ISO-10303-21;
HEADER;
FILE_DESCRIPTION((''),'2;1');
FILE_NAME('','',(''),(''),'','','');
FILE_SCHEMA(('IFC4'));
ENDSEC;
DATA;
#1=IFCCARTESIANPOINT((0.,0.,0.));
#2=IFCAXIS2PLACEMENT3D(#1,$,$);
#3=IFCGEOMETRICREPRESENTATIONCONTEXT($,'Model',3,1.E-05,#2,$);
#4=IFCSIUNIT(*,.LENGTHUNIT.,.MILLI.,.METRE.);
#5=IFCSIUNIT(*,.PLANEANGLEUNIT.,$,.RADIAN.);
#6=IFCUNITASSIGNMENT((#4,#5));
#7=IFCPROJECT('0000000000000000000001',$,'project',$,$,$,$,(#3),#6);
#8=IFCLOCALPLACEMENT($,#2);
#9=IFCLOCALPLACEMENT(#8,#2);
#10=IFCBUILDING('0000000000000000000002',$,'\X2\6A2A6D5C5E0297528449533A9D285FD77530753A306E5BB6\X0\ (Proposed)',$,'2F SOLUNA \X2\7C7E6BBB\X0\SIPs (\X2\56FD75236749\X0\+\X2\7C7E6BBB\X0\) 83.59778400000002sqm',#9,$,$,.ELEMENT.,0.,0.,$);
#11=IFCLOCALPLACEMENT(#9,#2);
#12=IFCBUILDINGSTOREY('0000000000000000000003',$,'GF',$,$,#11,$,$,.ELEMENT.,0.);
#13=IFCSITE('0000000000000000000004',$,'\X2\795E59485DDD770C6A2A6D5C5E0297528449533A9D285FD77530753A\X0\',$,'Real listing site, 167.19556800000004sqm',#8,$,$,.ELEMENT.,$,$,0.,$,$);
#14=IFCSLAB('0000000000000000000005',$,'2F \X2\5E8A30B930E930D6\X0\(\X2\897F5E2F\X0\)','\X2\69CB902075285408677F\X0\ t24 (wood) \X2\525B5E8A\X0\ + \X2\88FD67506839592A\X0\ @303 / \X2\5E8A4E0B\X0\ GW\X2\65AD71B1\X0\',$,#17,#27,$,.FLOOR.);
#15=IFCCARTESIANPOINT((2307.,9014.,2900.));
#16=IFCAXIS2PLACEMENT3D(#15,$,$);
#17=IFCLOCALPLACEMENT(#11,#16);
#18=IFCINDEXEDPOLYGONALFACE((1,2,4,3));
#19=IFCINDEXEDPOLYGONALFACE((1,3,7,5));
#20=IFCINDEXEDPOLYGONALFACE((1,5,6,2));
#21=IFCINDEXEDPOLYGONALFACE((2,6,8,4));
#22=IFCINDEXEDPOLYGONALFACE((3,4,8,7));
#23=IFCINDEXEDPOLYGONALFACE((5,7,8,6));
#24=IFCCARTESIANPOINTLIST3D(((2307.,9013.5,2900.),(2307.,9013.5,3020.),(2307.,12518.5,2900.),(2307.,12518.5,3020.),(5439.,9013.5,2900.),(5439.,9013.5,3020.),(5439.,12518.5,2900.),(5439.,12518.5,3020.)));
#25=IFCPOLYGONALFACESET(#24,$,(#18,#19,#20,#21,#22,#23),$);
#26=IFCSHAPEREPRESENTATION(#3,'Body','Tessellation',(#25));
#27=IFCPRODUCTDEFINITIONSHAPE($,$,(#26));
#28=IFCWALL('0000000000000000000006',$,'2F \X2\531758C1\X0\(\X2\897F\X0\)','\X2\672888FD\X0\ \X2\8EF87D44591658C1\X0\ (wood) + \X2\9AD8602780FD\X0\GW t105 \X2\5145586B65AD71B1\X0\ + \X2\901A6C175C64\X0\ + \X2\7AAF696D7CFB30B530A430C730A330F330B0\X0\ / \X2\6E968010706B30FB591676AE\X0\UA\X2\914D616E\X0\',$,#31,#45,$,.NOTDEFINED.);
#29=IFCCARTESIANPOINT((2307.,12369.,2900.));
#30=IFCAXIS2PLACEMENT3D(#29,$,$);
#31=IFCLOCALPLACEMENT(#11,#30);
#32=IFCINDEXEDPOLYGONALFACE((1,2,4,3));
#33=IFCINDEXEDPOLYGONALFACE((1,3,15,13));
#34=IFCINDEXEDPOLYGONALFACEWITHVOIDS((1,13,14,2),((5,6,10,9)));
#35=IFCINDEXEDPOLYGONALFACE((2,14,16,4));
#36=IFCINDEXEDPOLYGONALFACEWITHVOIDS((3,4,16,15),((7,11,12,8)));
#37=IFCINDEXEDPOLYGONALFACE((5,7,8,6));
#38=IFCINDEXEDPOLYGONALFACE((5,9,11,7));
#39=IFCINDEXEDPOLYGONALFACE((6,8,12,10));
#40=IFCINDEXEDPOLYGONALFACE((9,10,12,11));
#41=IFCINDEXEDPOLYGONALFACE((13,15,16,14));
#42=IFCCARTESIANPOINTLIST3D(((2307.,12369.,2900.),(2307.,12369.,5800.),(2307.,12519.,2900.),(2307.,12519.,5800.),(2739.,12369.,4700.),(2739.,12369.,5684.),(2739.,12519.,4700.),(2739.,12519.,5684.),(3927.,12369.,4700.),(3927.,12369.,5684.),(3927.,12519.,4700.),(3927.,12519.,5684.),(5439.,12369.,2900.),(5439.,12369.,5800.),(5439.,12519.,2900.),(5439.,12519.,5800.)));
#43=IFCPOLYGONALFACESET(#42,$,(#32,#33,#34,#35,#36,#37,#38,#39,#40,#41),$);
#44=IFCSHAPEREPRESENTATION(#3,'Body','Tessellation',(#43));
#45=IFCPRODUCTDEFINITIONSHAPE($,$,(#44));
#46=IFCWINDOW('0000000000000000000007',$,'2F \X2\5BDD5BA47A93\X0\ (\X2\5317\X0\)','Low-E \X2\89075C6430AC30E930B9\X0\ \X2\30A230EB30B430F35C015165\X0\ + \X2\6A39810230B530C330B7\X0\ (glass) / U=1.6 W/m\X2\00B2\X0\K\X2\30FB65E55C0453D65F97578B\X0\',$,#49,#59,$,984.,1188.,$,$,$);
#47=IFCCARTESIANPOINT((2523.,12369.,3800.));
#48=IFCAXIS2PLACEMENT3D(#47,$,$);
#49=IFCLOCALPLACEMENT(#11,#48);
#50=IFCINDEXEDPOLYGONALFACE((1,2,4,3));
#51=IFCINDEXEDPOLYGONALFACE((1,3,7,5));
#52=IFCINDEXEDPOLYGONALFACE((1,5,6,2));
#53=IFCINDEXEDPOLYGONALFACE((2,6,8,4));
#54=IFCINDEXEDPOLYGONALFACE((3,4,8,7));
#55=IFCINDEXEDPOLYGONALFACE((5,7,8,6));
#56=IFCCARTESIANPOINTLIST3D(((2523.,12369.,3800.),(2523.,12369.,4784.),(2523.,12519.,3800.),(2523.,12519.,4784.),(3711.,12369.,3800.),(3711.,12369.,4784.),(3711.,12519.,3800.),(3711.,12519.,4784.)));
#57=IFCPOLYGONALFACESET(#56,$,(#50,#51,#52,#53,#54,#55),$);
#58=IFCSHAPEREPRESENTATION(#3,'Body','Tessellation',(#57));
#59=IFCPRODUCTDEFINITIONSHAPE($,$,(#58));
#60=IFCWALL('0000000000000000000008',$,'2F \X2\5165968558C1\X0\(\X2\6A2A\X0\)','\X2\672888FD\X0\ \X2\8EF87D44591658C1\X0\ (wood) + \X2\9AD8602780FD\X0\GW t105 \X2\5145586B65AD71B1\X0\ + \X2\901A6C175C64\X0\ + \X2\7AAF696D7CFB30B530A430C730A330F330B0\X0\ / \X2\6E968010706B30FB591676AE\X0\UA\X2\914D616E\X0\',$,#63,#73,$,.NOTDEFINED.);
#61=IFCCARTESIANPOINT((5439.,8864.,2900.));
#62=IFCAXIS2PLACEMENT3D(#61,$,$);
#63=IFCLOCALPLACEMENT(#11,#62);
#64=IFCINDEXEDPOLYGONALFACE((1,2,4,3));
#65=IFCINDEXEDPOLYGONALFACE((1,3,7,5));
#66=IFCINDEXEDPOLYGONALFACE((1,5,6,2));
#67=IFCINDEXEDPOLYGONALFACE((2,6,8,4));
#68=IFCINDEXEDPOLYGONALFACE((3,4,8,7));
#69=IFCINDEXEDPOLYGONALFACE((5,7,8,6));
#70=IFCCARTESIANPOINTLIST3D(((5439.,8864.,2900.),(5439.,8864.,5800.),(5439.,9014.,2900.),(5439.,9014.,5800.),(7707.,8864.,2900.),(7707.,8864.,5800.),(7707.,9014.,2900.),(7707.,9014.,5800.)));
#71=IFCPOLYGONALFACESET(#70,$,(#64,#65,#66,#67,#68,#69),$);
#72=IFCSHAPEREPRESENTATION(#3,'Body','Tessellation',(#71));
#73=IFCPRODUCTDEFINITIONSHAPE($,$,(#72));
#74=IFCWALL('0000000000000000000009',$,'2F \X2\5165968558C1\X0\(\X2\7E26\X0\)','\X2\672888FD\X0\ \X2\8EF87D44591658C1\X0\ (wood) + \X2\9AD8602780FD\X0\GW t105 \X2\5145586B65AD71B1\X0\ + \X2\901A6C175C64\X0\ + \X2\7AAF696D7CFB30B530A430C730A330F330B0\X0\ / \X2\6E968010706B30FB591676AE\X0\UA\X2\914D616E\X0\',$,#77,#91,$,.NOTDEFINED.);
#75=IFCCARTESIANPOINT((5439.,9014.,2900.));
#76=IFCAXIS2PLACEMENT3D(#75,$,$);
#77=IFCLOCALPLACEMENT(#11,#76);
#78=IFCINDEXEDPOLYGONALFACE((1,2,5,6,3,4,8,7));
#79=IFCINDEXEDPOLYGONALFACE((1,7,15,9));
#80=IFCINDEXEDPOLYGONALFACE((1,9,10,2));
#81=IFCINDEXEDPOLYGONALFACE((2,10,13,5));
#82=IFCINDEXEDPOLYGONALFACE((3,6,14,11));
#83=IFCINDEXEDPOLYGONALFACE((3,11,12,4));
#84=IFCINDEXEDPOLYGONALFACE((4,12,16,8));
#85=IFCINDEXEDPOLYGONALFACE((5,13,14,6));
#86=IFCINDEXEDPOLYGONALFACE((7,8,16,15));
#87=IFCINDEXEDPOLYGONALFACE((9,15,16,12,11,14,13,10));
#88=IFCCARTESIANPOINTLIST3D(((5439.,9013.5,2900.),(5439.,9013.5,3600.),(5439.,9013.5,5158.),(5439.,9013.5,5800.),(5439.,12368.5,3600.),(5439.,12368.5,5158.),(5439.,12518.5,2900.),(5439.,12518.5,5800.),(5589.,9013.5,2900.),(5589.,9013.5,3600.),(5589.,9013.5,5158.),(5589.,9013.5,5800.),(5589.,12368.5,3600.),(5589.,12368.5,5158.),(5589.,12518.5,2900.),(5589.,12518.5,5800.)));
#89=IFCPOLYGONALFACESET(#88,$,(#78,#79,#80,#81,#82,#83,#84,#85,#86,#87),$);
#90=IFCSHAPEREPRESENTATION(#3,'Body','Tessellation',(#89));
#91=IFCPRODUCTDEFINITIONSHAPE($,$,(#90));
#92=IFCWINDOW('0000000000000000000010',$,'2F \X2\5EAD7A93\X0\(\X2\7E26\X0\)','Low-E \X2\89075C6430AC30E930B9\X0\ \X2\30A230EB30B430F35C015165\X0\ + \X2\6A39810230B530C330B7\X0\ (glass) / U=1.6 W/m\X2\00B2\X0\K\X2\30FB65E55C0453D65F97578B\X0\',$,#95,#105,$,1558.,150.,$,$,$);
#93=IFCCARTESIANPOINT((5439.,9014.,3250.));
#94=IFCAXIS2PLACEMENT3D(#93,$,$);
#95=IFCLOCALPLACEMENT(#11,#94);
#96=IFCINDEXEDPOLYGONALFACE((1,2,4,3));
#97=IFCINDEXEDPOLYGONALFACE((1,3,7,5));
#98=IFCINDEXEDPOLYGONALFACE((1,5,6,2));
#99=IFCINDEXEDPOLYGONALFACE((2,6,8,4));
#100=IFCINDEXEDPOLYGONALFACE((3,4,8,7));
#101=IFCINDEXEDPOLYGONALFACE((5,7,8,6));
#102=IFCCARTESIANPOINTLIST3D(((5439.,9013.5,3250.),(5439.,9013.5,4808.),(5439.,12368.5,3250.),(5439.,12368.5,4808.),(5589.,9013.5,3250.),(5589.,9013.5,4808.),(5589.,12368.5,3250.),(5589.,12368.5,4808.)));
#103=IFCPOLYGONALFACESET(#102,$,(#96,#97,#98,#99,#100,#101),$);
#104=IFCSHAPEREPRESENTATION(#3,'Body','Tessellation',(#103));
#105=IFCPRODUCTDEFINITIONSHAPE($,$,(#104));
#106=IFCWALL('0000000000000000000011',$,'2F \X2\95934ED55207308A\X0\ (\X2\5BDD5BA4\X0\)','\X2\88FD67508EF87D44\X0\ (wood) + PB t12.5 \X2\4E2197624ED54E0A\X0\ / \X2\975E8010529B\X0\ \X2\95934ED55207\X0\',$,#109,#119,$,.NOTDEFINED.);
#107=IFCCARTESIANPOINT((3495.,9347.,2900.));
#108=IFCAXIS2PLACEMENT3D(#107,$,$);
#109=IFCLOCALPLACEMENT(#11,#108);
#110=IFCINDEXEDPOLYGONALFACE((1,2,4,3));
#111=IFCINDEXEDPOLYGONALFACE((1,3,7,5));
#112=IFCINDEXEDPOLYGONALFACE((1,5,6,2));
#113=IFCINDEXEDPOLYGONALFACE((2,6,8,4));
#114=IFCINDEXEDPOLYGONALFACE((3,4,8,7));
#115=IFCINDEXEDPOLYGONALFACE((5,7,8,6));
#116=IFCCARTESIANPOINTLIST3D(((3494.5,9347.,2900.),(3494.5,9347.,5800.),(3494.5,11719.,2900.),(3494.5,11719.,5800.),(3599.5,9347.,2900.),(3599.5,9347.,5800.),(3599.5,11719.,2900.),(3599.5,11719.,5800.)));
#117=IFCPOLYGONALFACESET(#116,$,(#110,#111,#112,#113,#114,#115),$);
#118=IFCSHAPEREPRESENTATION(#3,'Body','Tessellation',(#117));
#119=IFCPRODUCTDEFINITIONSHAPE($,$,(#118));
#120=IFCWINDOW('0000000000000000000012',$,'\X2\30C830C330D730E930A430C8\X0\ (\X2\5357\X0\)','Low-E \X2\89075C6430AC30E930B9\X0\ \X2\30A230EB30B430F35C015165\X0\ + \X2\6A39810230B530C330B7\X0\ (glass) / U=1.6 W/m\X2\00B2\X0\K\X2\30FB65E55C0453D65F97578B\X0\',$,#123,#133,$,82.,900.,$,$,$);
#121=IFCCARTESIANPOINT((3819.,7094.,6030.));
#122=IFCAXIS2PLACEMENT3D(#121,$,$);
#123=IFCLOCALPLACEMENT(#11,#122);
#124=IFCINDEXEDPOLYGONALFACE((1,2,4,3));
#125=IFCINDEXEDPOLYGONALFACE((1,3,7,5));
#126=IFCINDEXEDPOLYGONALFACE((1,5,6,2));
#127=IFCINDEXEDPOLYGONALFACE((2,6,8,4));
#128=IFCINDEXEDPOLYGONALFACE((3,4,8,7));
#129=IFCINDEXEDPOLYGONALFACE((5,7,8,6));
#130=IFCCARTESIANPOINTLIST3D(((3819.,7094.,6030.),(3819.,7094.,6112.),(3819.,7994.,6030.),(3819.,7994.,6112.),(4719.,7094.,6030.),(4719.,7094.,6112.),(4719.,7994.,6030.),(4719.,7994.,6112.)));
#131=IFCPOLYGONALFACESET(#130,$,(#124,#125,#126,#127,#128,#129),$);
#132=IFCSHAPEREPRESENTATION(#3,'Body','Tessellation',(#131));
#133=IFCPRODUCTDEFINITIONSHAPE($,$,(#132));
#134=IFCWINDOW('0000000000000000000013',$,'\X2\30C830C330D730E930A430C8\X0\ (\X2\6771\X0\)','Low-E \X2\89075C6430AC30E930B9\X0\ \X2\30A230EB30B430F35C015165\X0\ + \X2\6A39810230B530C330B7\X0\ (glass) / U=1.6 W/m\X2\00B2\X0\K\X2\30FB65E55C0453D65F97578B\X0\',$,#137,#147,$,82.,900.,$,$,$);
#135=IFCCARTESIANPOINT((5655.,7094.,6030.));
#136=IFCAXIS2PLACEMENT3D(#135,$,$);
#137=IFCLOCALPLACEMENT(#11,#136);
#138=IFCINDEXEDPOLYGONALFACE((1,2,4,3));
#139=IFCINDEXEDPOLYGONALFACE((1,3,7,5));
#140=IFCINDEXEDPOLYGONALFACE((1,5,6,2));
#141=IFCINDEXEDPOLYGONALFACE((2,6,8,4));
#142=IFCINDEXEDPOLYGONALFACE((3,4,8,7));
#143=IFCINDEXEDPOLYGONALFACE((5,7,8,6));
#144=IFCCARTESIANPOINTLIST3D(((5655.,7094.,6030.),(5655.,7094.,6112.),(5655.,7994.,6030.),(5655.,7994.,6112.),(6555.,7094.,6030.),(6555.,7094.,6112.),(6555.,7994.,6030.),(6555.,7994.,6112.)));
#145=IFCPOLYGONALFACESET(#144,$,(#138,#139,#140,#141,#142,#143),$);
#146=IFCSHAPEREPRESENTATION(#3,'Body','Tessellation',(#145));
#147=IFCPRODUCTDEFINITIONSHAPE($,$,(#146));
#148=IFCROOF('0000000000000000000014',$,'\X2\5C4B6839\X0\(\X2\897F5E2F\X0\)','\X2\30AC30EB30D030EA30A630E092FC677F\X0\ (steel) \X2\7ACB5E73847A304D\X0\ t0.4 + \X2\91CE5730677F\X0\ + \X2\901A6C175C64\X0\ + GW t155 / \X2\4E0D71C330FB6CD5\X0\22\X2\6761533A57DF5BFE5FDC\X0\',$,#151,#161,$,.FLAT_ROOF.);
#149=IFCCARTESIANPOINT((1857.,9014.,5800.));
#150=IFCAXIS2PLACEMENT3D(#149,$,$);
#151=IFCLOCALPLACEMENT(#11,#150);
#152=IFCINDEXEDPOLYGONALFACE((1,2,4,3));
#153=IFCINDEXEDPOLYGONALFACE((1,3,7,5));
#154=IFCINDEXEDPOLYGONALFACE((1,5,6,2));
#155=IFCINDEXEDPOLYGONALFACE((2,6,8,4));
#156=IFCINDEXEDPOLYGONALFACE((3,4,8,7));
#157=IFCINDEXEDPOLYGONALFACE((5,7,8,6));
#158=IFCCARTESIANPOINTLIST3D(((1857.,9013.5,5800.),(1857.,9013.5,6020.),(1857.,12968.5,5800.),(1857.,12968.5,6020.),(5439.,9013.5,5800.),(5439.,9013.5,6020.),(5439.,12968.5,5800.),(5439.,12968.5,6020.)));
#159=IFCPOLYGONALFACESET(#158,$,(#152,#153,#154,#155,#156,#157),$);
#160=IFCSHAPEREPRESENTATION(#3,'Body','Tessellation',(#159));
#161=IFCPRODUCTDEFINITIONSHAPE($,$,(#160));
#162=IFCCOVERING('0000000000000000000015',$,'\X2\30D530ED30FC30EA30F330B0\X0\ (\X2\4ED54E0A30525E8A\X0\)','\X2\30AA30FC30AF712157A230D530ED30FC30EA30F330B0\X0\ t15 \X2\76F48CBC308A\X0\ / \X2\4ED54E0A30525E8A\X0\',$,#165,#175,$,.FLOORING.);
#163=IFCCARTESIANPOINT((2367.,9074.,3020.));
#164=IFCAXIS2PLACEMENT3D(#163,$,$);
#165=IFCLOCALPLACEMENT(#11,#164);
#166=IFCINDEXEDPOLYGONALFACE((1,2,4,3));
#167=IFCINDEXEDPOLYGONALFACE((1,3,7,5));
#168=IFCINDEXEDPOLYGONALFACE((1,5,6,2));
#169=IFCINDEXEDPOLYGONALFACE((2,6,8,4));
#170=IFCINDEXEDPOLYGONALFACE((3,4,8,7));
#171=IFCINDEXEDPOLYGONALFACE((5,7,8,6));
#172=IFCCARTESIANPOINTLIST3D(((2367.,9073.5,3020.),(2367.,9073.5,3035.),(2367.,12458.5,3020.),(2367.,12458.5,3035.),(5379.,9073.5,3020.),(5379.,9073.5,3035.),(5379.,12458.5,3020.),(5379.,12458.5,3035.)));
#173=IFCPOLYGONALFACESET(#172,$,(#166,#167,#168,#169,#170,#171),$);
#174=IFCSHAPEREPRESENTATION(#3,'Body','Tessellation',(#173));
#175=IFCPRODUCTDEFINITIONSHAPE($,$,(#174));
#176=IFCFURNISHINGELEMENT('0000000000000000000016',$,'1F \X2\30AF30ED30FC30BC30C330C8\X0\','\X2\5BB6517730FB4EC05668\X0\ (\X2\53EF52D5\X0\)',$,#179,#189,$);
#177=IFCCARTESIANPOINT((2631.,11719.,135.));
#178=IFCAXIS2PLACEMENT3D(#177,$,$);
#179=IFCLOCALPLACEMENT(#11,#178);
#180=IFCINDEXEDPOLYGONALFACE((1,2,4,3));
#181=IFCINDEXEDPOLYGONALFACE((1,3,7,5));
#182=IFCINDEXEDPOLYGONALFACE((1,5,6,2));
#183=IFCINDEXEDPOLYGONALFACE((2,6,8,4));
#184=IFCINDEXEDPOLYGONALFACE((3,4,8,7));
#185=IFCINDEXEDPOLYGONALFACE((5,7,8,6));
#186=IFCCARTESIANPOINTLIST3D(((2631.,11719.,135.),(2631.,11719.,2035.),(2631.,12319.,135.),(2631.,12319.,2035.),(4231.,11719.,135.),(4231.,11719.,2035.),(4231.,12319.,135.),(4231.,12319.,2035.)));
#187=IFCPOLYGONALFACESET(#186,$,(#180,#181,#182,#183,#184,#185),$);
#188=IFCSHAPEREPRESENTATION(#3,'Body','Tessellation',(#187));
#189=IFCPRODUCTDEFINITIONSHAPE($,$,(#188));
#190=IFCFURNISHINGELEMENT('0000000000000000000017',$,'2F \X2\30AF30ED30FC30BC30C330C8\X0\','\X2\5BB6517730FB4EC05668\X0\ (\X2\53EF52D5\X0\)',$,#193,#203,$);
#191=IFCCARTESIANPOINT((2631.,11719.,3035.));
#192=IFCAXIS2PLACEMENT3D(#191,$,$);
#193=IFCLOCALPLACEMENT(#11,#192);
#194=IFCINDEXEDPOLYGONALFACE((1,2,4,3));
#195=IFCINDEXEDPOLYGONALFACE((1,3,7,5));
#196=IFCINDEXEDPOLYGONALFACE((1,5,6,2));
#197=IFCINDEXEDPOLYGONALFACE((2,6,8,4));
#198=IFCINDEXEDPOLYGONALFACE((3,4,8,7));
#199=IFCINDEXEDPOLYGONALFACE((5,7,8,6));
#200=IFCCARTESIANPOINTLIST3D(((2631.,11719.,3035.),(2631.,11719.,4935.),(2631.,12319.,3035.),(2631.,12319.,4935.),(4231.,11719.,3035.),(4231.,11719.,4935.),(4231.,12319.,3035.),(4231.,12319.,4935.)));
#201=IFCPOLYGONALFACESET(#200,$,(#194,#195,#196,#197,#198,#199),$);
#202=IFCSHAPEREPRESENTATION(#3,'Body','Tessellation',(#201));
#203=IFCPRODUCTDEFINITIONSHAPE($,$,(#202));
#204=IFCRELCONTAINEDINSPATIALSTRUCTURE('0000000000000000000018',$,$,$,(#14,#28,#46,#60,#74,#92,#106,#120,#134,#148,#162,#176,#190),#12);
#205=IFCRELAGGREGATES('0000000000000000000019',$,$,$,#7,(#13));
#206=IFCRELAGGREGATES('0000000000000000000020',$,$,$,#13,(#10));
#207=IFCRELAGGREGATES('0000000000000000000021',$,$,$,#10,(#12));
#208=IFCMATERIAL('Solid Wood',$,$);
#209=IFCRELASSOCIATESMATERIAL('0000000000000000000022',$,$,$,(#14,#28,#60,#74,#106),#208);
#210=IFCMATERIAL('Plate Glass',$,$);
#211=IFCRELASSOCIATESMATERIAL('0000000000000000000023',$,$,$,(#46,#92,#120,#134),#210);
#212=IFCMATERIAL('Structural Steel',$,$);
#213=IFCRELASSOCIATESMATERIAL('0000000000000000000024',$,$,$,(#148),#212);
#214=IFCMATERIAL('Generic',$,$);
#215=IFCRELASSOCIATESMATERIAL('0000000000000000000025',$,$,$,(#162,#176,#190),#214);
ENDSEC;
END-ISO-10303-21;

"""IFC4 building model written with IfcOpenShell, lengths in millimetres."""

from ifc_helpers import new_model, si_unit, frame, frame_2d, origin, place, context, project, spatial, rectangle, extrude, material, element, fill, save


model = new_model("IFC4")

# Units and contexts
model_context = context("Model", 3, precision=1e-05, world=origin())
ifc_project = project(units=[si_unit("LENGTHUNIT", "METRE", prefix="MILLI"), si_unit("PLANEANGLEUNIT", "RADIAN")], contexts=[model_context])

# Site, building, storey
site_placement = place(None, origin())
site = spatial("IfcSite", under=ifc_project, at=site_placement, Name="神奈川県横浜市青葉区鴨志田町", ObjectType="Real listing site, 167.19556800000004sqm", CompositionType="ELEMENT", RefElevation=0.0)
building_placement = place(site_placement, origin())
building = spatial("IfcBuilding", under=site, at=building_placement, Name="横浜市青葉区鴨志田町の家 (Proposed)", ObjectType="2F SOLUNA 籾殻SIPs (国産杉+籾殻) 83.59778400000002sqm", CompositionType="ELEMENT", ElevationOfRefHeight=0.0, ElevationOfTerrain=0.0)
storey_placement = place(building_placement, origin())
storey = spatial("IfcBuildingStorey", under=building, at=storey_placement, Name="GF", CompositionType="ELEMENT", Elevation=0.0)

# Slab
ifc_material_1 = material(Name="Solid Wood")
slab_placement = place(storey_placement, frame((2307.0, 9014.0, 2900.0)))
element("IfcSlab", 1, at=slab_placement, inside=storey, material=ifc_material_1, Name="2F 床スラブ(西帯)", Description="構造用合板 t24 (wood) 剛床 + 製材根太 @303 / 床下 GW断熱", PredefinedType="FLOOR", context=model_context, shape_type="SweptSolid", body=[
    extrude(rectangle(XDim=3132.0, YDim=3505.0, at=frame_2d((1566.0, 1752.0))), frame((2307.0, 9014.0, 2900.0)), (0.0, 0.0, 1.0), 120.0),
])

# Wall, opening, window
wall_1_placement = place(storey_placement, frame((2307.0, 12369.0, 2900.0)))
wall_1 = element("IfcWall", 2, at=wall_1_placement, inside=storey, material=ifc_material_1, Name="2F 北壁(西)", Description="木製 軸組外壁 (wood) + 高性能GW t105 充填断熱 + 通気層 + 窯業系サイディング / 準耐火・外皮UA配慮", PredefinedType="NOTDEFINED", context=model_context, shape_type="SweptSolid", body=[
    extrude(rectangle(XDim=3132.0, YDim=150.0, at=frame_2d((1566.0, 75.0))), frame((2307.0, 12369.0, 2900.0)), (0.0, 0.0, 1.0), 2900.0),
])
opening_1_placement = place(storey_placement, frame((2523.0, 12369.0, 3800.0)))
opening_1 = element("IfcOpeningElement", 3, at=opening_1_placement, cuts=wall_1, PredefinedType="NOTDEFINED", context=model_context, shape_type="SweptSolid", body=[
    extrude(rectangle(XDim=1188.0, YDim=150.0, at=frame_2d((594.0, 75.0))), frame((2523.0, 12369.0, 3800.0)), (0.0, 0.0, 1.0), 984.0),
])
ifc_material_2 = material(Name="Plate Glass")
window_1_placement = place(storey_placement, frame((2523.0, 12369.0, 3800.0)))
window_1 = element("IfcWindow", 4, at=window_1_placement, inside=storey, material=ifc_material_2, Name="2F 寝室窓 (北)", Description="Low-E 複層ガラス アルゴン封入 + 樹脂サッシ (glass) / U=1.6 W/m²K・日射取得型", OverallHeight=984.0, OverallWidth=1188.0, context=model_context, shape_type="SweptSolid", body=[
    extrude(rectangle(XDim=1188.0, YDim=150.0, at=frame_2d((594.0, 75.0))), frame((2523.0, 12369.0, 3800.0)), (0.0, 0.0, 1.0), 984.0),
])
fill(opening_1, window_1)

# Wall
wall_2_placement = place(storey_placement, frame((5439.0, 8864.0, 2900.0)))
element("IfcWall", 5, at=wall_2_placement, inside=storey, material=ifc_material_1, Name="2F 入隅壁(横)", Description="木製 軸組外壁 (wood) + 高性能GW t105 充填断熱 + 通気層 + 窯業系サイディング / 準耐火・外皮UA配慮", PredefinedType="NOTDEFINED", context=model_context, shape_type="SweptSolid", body=[
    extrude(rectangle(XDim=2268.0, YDim=150.0, at=frame_2d((1134.0, 75.0))), frame((5439.0, 8864.0, 2900.0)), (0.0, 0.0, 1.0), 2900.0),
])

# Wall, opening, window
wall_3_placement = place(storey_placement, frame((5439.0, 9014.0, 2900.0)))
wall_3 = element("IfcWall", 6, at=wall_3_placement, inside=storey, material=ifc_material_1, Name="2F 入隅壁(縦)", Description="木製 軸組外壁 (wood) + 高性能GW t105 充填断熱 + 通気層 + 窯業系サイディング / 準耐火・外皮UA配慮", PredefinedType="NOTDEFINED", context=model_context, shape_type="SweptSolid", body=[
    extrude(rectangle(XDim=150.0, YDim=3505.0, at=frame_2d((75.0, 1752.0))), frame((5439.0, 9014.0, 2900.0)), (0.0, 0.0, 1.0), 2900.0),
])
opening_2_placement = place(storey_placement, frame((5439.0, 9014.0, 3250.0)))
opening_2 = element("IfcOpeningElement", 7, at=opening_2_placement, cuts=wall_3, PredefinedType="NOTDEFINED", context=model_context, shape_type="SweptSolid", body=[
    extrude(rectangle(XDim=150.0, YDim=3355.0, at=frame_2d((75.0, 1677.0))), frame((5439.0, 9014.0, 3250.0)), (0.0, 0.0, 1.0), 1558.0),
])
window_2_placement = place(storey_placement, frame((5439.0, 9014.0, 3250.0)))
window_2 = element("IfcWindow", 8, at=window_2_placement, inside=storey, material=ifc_material_2, Name="2F 庭窓(縦)", Description="Low-E 複層ガラス アルゴン封入 + 樹脂サッシ (glass) / U=1.6 W/m²K・日射取得型", OverallHeight=1558.0, OverallWidth=150.0, context=model_context, shape_type="SweptSolid", body=[
    extrude(rectangle(XDim=150.0, YDim=3355.0, at=frame_2d((75.0, 1677.0))), frame((5439.0, 9014.0, 3250.0)), (0.0, 0.0, 1.0), 1558.0),
])
fill(opening_2, window_2)

# Wall
wall_4_placement = place(storey_placement, frame((3495.0, 9347.0, 2900.0)))
element("IfcWall", 9, at=wall_4_placement, inside=storey, material=ifc_material_1, Name="2F 間仕切り (寝室)", Description="製材軸組 (wood) + PB t12.5 両面仕上 / 非耐力 間仕切", PredefinedType="NOTDEFINED", context=model_context, shape_type="SweptSolid", body=[
    extrude(rectangle(XDim=105.0, YDim=2372.0, at=frame_2d((52.0, 1186.0))), frame((3495.0, 9347.0, 2900.0)), (0.0, 0.0, 1.0), 2900.0),
])

# Windows
window_3_placement = place(storey_placement, frame((3819.0, 7094.0, 6030.0)))
element("IfcWindow", 10, at=window_3_placement, inside=storey, material=ifc_material_2, Name="トップライト (南)", Description="Low-E 複層ガラス アルゴン封入 + 樹脂サッシ (glass) / U=1.6 W/m²K・日射取得型", OverallHeight=82.0, OverallWidth=900.0, context=model_context, shape_type="SweptSolid", body=[
    extrude(rectangle(XDim=900.0, YDim=900.0, at=frame_2d((450.0, 450.0))), frame((3819.0, 7094.0, 6030.0)), (0.0, 0.0, 1.0), 82.0),
])
window_4_placement = place(storey_placement, frame((5655.0, 7094.0, 6030.0)))
element("IfcWindow", 11, at=window_4_placement, inside=storey, material=ifc_material_2, Name="トップライト (東)", Description="Low-E 複層ガラス アルゴン封入 + 樹脂サッシ (glass) / U=1.6 W/m²K・日射取得型", OverallHeight=82.0, OverallWidth=900.0, context=model_context, shape_type="SweptSolid", body=[
    extrude(rectangle(XDim=900.0, YDim=900.0, at=frame_2d((450.0, 450.0))), frame((5655.0, 7094.0, 6030.0)), (0.0, 0.0, 1.0), 82.0),
])

# Roof
ifc_material_3 = material(Name="Structural Steel")
for number, where, name in (
    (12, (1857.0, 9014.0, 5800.0), "屋根(西帯)"),
):
    element("IfcRoof", number, at=place(storey_placement, frame(where)), inside=storey, material=ifc_material_3, Name=name, Description="ガルバリウム鋼板 (steel) 立平葺き t0.4 + 野地板 + 通気層 + GW t155 / 不燃・法22条区域対応", PredefinedType="FLAT_ROOF", context=model_context, shape_type="SweptSolid", body=[
        extrude(rectangle(XDim=3582.0, YDim=3955.0, at=frame_2d((1791.0, 1977.0))), frame((1857.0, 9014.0, 5800.0)), (0.0, 0.0, 1.0), 220.0),
    ])

# Covering
ifc_material_4 = material(Name="Generic")
covering_placement = place(storey_placement, frame((2367.0, 9074.0, 3020.0)))
element("IfcCovering", 13, at=covering_placement, inside=storey, material=ifc_material_4, Name="フローリング (仕上げ床)", Description="オーク無垢フローリング t15 直貼り / 仕上げ床", PredefinedType="FLOORING", context=model_context, shape_type="SweptSolid", body=[
    extrude(rectangle(XDim=3012.0, YDim=3385.0, at=frame_2d((1506.0, 1692.0))), frame((2367.0, 9074.0, 3020.0)), (0.0, 0.0, 1.0), 15.0),
])

# Furnishing elements
furnishing_1_placement = place(storey_placement, frame((2631.0, 11719.0, 135.0)))
element("IfcFurnishingElement", 14, at=furnishing_1_placement, inside=storey, material=ifc_material_4, Name="1F クローゼット", Description="家具・什器 (可動)", context=model_context, shape_type="SweptSolid", body=[
    extrude(rectangle(XDim=1600.0, YDim=600.0, at=frame_2d((800.0, 300.0))), frame((2631.0, 11719.0, 135.0)), (0.0, 0.0, 1.0), 1900.0),
])
furnishing_2_placement = place(storey_placement, frame((2631.0, 11719.0, 3035.0)))
element("IfcFurnishingElement", 15, at=furnishing_2_placement, inside=storey, material=ifc_material_4, Name="2F クローゼット", Description="家具・什器 (可動)", context=model_context, shape_type="SweptSolid", body=[
    extrude(rectangle(XDim=1600.0, YDim=600.0, at=frame_2d((800.0, 300.0))), frame((2631.0, 11719.0, 3035.0)), (0.0, 0.0, 1.0), 1900.0),
])

save(model, "model.ifc")
